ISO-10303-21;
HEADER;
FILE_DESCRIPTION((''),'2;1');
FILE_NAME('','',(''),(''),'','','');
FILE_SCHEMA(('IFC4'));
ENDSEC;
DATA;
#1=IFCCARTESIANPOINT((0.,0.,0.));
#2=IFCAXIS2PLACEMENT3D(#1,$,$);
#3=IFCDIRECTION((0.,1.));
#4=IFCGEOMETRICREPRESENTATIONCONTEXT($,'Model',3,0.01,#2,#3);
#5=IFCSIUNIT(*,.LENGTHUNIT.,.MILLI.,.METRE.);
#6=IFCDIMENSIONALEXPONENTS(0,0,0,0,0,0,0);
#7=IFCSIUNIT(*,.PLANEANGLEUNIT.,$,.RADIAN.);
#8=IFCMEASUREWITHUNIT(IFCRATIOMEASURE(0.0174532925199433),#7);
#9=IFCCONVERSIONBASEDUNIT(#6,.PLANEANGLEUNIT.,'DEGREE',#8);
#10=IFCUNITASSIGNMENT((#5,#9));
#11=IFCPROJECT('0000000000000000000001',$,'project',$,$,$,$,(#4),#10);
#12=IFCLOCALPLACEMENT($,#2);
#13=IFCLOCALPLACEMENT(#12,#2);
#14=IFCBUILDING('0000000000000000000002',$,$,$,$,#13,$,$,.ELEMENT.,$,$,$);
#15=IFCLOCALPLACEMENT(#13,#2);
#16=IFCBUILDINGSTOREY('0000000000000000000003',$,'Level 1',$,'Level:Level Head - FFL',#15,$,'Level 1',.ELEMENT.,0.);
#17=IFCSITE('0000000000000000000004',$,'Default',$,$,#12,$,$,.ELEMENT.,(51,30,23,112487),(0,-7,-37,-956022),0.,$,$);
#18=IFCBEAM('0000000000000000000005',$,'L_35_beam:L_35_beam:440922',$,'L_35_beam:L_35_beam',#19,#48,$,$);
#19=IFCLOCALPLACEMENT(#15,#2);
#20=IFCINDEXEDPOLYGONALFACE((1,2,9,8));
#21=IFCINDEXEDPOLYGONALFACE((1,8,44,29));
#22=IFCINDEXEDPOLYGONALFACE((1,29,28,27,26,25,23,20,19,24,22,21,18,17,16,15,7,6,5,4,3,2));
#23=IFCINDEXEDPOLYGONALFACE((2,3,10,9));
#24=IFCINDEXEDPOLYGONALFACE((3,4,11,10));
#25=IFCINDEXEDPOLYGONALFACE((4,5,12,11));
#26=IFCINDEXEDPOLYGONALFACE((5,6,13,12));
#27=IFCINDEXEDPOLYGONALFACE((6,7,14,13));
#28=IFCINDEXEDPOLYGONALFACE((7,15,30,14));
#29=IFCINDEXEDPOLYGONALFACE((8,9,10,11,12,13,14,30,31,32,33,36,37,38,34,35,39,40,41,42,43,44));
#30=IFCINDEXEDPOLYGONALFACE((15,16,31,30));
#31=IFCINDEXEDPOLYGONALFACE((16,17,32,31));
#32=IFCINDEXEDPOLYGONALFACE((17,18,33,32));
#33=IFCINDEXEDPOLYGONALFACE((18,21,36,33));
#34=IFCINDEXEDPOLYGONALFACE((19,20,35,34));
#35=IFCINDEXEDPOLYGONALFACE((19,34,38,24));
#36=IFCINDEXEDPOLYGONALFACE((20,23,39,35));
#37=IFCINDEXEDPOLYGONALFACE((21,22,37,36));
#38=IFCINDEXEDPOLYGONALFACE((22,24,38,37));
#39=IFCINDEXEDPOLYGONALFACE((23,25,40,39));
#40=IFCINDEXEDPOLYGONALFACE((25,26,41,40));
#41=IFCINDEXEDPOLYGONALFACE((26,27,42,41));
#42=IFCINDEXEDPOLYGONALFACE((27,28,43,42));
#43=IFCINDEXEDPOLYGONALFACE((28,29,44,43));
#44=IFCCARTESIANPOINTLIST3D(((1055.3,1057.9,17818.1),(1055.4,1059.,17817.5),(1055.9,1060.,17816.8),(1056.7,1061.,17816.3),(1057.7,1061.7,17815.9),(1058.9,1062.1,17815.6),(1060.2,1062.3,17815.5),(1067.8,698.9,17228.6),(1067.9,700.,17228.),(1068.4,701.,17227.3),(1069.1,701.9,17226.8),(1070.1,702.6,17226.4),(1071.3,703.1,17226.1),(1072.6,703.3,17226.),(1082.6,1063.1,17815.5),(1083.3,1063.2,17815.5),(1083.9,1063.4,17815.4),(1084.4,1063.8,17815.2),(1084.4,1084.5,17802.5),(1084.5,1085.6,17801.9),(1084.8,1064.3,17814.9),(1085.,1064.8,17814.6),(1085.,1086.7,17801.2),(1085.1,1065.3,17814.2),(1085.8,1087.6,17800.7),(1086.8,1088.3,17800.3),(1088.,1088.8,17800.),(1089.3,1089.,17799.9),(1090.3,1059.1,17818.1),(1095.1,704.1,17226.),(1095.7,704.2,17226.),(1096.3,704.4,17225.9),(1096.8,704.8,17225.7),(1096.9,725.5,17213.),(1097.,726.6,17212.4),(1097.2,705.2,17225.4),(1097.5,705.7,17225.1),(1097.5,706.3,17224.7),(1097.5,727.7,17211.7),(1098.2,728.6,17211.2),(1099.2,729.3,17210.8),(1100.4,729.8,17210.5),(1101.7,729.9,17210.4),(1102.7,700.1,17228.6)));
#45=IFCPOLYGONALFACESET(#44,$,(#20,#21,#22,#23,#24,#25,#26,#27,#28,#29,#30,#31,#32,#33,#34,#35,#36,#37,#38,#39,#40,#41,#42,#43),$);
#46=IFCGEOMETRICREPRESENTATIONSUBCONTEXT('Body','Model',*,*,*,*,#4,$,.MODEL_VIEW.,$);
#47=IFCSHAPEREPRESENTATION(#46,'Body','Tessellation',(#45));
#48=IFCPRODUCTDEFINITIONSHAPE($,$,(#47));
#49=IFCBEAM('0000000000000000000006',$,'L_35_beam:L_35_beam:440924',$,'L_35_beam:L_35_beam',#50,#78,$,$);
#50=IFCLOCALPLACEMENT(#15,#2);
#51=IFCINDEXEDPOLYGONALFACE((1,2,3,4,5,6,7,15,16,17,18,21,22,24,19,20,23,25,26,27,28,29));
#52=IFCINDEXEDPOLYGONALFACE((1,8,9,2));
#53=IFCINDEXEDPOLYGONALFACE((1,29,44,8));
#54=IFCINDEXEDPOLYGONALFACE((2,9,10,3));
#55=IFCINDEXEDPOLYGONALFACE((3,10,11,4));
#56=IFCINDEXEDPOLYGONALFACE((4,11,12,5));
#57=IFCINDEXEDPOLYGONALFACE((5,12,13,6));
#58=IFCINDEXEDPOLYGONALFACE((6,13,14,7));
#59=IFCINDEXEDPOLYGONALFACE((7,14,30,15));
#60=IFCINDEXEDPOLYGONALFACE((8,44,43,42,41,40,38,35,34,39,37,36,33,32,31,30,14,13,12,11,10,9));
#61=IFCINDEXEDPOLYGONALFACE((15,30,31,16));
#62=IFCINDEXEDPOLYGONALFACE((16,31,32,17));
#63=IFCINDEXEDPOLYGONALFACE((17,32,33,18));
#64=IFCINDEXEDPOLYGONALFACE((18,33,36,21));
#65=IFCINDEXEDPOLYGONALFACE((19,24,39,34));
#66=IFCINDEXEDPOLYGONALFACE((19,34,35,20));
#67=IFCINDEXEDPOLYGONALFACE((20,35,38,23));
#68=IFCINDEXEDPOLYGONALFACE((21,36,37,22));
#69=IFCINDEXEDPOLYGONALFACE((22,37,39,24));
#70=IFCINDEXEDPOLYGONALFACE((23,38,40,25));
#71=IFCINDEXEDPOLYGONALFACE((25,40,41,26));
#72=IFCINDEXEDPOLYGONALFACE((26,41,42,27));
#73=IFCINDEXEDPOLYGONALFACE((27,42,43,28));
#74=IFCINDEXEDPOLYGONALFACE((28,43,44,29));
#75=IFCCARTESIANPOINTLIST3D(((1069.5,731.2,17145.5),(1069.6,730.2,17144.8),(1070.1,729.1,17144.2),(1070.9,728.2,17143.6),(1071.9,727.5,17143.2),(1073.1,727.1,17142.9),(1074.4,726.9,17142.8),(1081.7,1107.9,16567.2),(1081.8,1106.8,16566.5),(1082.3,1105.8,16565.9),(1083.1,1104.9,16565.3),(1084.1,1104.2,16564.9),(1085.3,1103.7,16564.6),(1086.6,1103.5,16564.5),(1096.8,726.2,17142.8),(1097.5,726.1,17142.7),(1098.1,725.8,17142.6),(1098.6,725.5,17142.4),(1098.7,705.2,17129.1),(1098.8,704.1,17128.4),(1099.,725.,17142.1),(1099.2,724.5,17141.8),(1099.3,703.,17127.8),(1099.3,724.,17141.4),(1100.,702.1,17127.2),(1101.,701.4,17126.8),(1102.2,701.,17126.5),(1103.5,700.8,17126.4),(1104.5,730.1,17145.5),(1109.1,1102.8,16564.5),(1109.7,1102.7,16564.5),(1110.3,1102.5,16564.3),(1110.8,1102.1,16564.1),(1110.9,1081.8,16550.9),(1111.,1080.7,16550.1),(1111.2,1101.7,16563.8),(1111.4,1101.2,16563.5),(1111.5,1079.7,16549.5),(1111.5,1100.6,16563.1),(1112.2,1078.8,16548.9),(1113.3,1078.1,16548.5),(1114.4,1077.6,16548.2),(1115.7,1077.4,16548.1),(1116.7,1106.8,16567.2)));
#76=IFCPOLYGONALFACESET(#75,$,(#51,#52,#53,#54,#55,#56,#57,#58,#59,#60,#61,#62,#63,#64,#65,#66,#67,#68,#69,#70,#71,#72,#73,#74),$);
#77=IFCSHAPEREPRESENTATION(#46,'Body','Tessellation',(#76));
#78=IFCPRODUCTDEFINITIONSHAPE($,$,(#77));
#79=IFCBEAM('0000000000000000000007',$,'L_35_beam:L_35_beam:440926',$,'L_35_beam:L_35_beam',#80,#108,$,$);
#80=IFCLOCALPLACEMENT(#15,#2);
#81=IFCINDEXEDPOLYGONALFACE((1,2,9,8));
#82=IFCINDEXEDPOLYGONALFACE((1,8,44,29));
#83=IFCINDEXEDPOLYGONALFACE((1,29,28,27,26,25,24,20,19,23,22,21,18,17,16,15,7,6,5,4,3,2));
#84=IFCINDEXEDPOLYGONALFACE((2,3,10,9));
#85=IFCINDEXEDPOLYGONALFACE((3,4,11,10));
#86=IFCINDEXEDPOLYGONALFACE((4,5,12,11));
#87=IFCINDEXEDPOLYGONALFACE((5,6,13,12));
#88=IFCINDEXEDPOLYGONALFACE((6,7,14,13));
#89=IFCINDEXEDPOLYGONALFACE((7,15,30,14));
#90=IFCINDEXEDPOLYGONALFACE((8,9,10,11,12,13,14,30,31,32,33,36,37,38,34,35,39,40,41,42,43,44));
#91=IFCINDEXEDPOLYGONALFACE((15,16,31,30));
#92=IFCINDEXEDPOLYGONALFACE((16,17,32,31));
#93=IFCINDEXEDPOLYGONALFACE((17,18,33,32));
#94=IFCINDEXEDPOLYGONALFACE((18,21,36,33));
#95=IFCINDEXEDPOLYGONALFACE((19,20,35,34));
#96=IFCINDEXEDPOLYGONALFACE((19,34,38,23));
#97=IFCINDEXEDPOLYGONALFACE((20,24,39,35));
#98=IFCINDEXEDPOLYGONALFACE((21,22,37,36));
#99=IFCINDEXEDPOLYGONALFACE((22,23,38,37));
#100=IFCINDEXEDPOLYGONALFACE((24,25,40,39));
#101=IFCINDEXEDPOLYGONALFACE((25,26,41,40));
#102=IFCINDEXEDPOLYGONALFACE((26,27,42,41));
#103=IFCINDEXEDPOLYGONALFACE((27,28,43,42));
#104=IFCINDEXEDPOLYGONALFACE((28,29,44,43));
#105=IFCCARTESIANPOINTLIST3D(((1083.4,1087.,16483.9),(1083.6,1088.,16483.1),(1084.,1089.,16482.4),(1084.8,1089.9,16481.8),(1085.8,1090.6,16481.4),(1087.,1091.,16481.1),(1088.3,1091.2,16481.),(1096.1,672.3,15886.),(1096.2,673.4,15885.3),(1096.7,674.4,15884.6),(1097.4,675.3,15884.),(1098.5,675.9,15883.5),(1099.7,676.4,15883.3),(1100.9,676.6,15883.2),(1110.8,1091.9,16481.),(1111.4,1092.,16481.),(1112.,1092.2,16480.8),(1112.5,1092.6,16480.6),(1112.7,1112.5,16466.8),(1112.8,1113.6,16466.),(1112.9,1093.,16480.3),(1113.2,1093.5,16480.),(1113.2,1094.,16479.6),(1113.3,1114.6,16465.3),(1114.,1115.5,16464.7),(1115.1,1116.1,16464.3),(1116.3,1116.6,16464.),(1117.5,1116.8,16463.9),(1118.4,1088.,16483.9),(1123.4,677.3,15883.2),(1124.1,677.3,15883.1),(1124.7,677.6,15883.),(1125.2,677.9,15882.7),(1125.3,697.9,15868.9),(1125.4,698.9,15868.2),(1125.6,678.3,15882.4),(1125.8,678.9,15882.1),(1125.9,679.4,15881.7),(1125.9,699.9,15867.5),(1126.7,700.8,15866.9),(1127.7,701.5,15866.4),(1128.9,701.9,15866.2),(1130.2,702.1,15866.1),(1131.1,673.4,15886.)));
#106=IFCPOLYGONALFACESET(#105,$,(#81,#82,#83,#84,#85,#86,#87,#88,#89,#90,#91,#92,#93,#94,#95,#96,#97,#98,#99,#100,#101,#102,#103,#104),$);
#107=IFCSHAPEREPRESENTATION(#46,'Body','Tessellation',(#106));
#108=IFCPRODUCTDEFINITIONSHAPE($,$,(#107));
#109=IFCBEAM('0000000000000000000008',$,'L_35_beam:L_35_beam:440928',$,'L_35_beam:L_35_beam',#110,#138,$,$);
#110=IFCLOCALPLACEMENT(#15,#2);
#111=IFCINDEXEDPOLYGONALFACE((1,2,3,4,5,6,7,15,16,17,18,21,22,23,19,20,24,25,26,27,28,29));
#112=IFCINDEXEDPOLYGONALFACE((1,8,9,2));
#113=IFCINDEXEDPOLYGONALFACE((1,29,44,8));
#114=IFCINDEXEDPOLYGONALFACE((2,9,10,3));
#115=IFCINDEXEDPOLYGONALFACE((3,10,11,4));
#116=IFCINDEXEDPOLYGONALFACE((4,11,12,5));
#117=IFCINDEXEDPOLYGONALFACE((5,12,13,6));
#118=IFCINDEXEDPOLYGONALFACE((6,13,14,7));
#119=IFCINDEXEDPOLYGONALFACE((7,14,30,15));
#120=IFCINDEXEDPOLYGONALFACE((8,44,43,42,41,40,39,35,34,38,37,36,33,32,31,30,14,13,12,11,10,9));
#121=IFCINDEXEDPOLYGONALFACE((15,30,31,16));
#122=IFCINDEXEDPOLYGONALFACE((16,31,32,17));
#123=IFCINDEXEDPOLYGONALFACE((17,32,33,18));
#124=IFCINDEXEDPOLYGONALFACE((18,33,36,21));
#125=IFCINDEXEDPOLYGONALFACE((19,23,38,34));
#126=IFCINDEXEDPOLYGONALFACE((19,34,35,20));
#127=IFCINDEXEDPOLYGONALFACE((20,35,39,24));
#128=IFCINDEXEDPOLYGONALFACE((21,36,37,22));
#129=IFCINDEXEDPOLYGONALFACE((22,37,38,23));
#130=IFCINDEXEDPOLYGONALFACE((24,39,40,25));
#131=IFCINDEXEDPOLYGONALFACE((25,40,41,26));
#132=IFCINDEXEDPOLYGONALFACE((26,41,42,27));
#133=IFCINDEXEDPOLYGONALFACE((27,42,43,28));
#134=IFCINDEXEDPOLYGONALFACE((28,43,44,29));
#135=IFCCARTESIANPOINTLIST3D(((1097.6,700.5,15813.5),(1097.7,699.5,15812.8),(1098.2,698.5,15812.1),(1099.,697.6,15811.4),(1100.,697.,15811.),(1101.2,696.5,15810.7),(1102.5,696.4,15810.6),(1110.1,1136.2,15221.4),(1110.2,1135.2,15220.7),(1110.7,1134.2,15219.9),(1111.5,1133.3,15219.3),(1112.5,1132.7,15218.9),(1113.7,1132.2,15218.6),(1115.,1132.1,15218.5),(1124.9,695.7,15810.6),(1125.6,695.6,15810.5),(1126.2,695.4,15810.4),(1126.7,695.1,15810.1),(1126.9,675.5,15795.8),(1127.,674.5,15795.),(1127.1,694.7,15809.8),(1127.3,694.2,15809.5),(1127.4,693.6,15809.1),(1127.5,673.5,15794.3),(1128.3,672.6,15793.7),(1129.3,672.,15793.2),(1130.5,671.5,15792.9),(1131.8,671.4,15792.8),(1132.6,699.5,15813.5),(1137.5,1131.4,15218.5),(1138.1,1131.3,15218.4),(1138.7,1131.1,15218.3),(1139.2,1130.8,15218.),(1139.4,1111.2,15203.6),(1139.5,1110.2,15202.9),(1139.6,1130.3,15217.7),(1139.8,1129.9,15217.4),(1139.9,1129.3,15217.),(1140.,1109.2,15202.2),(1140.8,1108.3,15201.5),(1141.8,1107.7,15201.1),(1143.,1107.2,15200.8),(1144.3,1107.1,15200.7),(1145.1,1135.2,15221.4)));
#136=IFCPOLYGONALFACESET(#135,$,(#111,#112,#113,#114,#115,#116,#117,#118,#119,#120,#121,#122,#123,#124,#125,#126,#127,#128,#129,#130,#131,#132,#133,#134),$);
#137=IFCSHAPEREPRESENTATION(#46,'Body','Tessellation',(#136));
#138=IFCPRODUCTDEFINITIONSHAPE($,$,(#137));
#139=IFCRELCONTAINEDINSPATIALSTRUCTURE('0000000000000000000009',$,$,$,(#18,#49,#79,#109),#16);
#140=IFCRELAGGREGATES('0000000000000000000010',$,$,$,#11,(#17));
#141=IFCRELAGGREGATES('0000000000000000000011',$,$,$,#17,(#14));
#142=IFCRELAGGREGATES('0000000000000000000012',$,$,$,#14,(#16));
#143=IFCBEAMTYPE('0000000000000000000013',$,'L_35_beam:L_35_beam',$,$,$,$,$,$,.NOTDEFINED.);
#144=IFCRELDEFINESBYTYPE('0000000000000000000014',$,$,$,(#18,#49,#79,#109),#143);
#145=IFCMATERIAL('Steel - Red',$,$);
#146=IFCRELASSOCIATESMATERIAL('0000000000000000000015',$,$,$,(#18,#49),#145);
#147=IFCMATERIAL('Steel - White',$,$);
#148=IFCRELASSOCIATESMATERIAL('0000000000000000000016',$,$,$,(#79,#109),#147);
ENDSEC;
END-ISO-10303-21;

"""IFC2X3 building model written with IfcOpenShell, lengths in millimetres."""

from ifc_helpers import new_model, entity, si_unit, converted_unit, direction, frame, frame_2d, origin, place, context, subcontext, project, spatial, polyline, circle_curve, parameter, trimmed, segment, composite_curve, outline, extrude, material, type_object, element, save


model = new_model("IFC2X3")

# Units and contexts
model_context = context("Model", 3, precision=0.01, world=origin(), true_north=direction((0.0, 1.0)))
body_context = subcontext(model_context, "Body", "Model", "MODEL_VIEW")
ifc_project = project(units=[si_unit("LENGTHUNIT", "METRE", prefix="MILLI"), converted_unit("PLANEANGLEUNIT", "DEGREE", entity("IfcRatioMeasure", 0.0174532925199433), si_unit("PLANEANGLEUNIT", "RADIAN"), dimensions=[0, 0, 0, 0, 0, 0, 0])], contexts=[model_context])

# Site, building, storey
site_placement = place(None, origin())
site = spatial("IfcSite", under=ifc_project, at=site_placement, Name="Default", CompositionType="ELEMENT", RefLatitude=(51, 30, 23, 112487), RefLongitude=(0, -7, -37, -956022), RefElevation=0.0)
building_placement = place(site_placement, origin())
building = spatial("IfcBuilding", under=site, at=building_placement, CompositionType="ELEMENT")
storey_placement = place(building_placement, origin())
storey = spatial("IfcBuildingStorey", under=building, at=storey_placement, Name="Level 1", ObjectType="Level:Level Head - FFL", LongName="Level 1", CompositionType="ELEMENT", Elevation=0.0)

# Beams
ifc_material_1 = material(Name="Steel - Red")
ifc_material_2 = material(Name="Steel - White")
beam_type_1 = type_object("IfcBeamType", Name="L_35_beam:L_35_beam", PredefinedType="NOTDEFINED")
beam_1_placement = place(storey_placement, frame((1097.0, 1096.9, 17846.1), z_axis=(0.999837, 0.009385, 0.01541), x_axis=(0.018043, -0.520075, -0.85393)))
element("IfcBeam", 1, at=beam_1_placement, inside=storey, type_object=beam_type_1, material=ifc_material_1, Name="L_35_beam:L_35_beam:440922", ObjectType="L_35_beam:L_35_beam", context=body_context, shape_type="SweptSolid", body=[
    extrude(outline(composite_curve([segment(polyline([(-23.2, -11.8), (11.8, -11.8)]), True, "CONTINUOUS"), segment(polyline([(11.8, -11.8), (11.8, 23.2)]), True, "CONTINUOUS"), segment(trimmed(circle_curve(frame_2d((11.8, 18.2), x_axis=(0.0, 1.0)), 5.0), [parameter(0.0)], [parameter(90.0)], True, "PARAMETER"), True, "CONTINUOUS"), segment(polyline([(6.8, 18.2), (6.8, -4.3)]), True, "CONTINUOUS"), segment(trimmed(circle_curve(frame_2d((4.3, -4.3), x_axis=(1.0, 0.0)), 2.5), [parameter(270.0)], [parameter(0.0)], True, "PARAMETER"), False, "CONTINUOUS"), segment(polyline([(4.3, -6.8), (-18.2, -6.8)]), True, "CONTINUOUS"), segment(trimmed(circle_curve(frame_2d((-18.2, -11.8), x_axis=(0.0, 1.0)), 5.0), [parameter(0.0)], [parameter(90.0)], True, "PARAMETER"), True, "CONTINUOUS")], self_intersect=False)), frame((43.4, -6.3, -19.6), z_axis=(1.0, 0.0, 0.0), x_axis=(0.0, -0.999561, 0.029613)), (0.0, 0.0, 1.0), 690.3),
])
beam_2_placement = place(storey_placement, frame((1125.3, 1125.2, 16506.4), z_axis=(0.999843, -0.009661, 0.014834), x_axis=(-0.017703, -0.545672, 0.837812)))
element("IfcBeam", 2, at=beam_2_placement, inside=storey, type_object=beam_type_1, material=ifc_material_1, Name="L_35_beam:L_35_beam:440924", ObjectType="L_35_beam:L_35_beam", context=body_context, shape_type="SweptSolid", body=[
    extrude(outline(composite_curve([segment(polyline([(-23.2, -11.8), (11.8, -11.8)]), True, "CONTINUOUS"), segment(polyline([(11.8, -11.8), (11.8, 23.2)]), True, "CONTINUOUS"), segment(trimmed(circle_curve(frame_2d((11.8, 18.2), x_axis=(0.0, 1.0)), 5.0), [parameter(0.0)], [parameter(90.0)], True, "PARAMETER"), True, "CONTINUOUS"), segment(polyline([(6.8, 18.2), (6.8, -4.3)]), True, "CONTINUOUS"), segment(trimmed(circle_curve(frame_2d((4.3, -4.3), x_axis=(1.0, 0.0)), 2.5), [parameter(270.0)], [parameter(0.0)], True, "PARAMETER"), False, "CONTINUOUS"), segment(polyline([(4.3, -6.8), (-18.2, -6.8)]), True, "CONTINUOUS"), segment(trimmed(circle_curve(frame_2d((-18.2, -11.8), x_axis=(0.0, 1.0)), 5.0), [parameter(0.0)], [parameter(90.0)], True, "PARAMETER"), True, "CONTINUOUS")], self_intersect=False)), frame((61.2, -6.2, -19.6), z_axis=(1.0, 0.0, 0.0), x_axis=(0.0, -0.999631, 0.02717)), (0.0, 0.0, 1.0), 690.2),
])
beam_3_placement = place(storey_placement, frame((1125.3, 1125.2, 16506.4), z_axis=(0.999849, 0.009893, 0.014264), x_axis=(0.01736, -0.569827, -0.821581)))
element("IfcBeam", 3, at=beam_3_placement, inside=storey, type_object=beam_type_1, material=ifc_material_2, Name="L_35_beam:L_35_beam:440926", ObjectType="L_35_beam:L_35_beam", context=body_context, shape_type="SweptSolid", body=[
    extrude(outline(composite_curve([segment(polyline([(-23.2, -11.8), (11.8, -11.8)]), True, "CONTINUOUS"), segment(polyline([(11.8, -11.8), (11.8, 23.2)]), True, "CONTINUOUS"), segment(trimmed(circle_curve(frame_2d((11.8, 18.2), x_axis=(0.0, 1.0)), 5.0), [parameter(0.0)], [parameter(90.0)], True, "PARAMETER"), True, "CONTINUOUS"), segment(polyline([(6.8, 18.2), (6.8, -4.3)]), True, "CONTINUOUS"), segment(trimmed(circle_curve(frame_2d((4.3, -4.3), x_axis=(1.0, 0.0)), 2.5), [parameter(270.0)], [parameter(0.0)], True, "PARAMETER"), False, "CONTINUOUS"), segment(polyline([(4.3, -6.8), (-18.2, -6.8)]), True, "CONTINUOUS"), segment(trimmed(circle_curve(frame_2d((-18.2, -11.8), x_axis=(0.0, 1.0)), 5.0), [parameter(0.0)], [parameter(90.0)], True, "PARAMETER"), True, "CONTINUOUS")], self_intersect=False)), frame((39.6, -6.2, -19.6), z_axis=(1.0, 0.0, 0.0), x_axis=(0.0, -0.999687, 0.025021)), (0.0, 0.0, 1.0), 727.7),
])
beam_4_placement = place(storey_placement, frame((1153.6, 1153.5, 15166.7), z_axis=(0.999855, -0.010085, 0.013705), x_axis=(-0.017016, -0.592591, 0.805324)))
element("IfcBeam", 4, at=beam_4_placement, inside=storey, type_object=beam_type_1, material=ifc_material_2, Name="L_35_beam:L_35_beam:440928", ObjectType="L_35_beam:L_35_beam", context=body_context, shape_type="SweptSolid", body=[
    extrude(outline(composite_curve([segment(polyline([(-23.2, -11.8), (11.8, -11.8)]), True, "CONTINUOUS"), segment(polyline([(11.8, -11.8), (11.8, 23.2)]), True, "CONTINUOUS"), segment(trimmed(circle_curve(frame_2d((11.8, 18.2), x_axis=(0.0, 1.0)), 5.0), [parameter(0.0)], [parameter(90.0)], True, "PARAMETER"), True, "CONTINUOUS"), segment(polyline([(6.8, 18.2), (6.8, -4.3)]), True, "CONTINUOUS"), segment(trimmed(circle_curve(frame_2d((4.3, -4.3), x_axis=(1.0, 0.0)), 2.5), [parameter(270.0)], [parameter(0.0)], True, "PARAMETER"), False, "CONTINUOUS"), segment(polyline([(4.3, -6.8), (-18.2, -6.8)]), True, "CONTINUOUS"), segment(trimmed(circle_curve(frame_2d((-18.2, -11.8), x_axis=(0.0, 1.0)), 5.0), [parameter(0.0)], [parameter(90.0)], True, "PARAMETER"), True, "CONTINUOUS")], self_intersect=False)), frame((55.0, -6.2, -19.6), z_axis=(1.0, 0.0, 0.0), x_axis=(0.0, -0.999733, 0.023118)), (0.0, 0.0, 1.0), 735.2),
])

save(model, "model.ifc")
